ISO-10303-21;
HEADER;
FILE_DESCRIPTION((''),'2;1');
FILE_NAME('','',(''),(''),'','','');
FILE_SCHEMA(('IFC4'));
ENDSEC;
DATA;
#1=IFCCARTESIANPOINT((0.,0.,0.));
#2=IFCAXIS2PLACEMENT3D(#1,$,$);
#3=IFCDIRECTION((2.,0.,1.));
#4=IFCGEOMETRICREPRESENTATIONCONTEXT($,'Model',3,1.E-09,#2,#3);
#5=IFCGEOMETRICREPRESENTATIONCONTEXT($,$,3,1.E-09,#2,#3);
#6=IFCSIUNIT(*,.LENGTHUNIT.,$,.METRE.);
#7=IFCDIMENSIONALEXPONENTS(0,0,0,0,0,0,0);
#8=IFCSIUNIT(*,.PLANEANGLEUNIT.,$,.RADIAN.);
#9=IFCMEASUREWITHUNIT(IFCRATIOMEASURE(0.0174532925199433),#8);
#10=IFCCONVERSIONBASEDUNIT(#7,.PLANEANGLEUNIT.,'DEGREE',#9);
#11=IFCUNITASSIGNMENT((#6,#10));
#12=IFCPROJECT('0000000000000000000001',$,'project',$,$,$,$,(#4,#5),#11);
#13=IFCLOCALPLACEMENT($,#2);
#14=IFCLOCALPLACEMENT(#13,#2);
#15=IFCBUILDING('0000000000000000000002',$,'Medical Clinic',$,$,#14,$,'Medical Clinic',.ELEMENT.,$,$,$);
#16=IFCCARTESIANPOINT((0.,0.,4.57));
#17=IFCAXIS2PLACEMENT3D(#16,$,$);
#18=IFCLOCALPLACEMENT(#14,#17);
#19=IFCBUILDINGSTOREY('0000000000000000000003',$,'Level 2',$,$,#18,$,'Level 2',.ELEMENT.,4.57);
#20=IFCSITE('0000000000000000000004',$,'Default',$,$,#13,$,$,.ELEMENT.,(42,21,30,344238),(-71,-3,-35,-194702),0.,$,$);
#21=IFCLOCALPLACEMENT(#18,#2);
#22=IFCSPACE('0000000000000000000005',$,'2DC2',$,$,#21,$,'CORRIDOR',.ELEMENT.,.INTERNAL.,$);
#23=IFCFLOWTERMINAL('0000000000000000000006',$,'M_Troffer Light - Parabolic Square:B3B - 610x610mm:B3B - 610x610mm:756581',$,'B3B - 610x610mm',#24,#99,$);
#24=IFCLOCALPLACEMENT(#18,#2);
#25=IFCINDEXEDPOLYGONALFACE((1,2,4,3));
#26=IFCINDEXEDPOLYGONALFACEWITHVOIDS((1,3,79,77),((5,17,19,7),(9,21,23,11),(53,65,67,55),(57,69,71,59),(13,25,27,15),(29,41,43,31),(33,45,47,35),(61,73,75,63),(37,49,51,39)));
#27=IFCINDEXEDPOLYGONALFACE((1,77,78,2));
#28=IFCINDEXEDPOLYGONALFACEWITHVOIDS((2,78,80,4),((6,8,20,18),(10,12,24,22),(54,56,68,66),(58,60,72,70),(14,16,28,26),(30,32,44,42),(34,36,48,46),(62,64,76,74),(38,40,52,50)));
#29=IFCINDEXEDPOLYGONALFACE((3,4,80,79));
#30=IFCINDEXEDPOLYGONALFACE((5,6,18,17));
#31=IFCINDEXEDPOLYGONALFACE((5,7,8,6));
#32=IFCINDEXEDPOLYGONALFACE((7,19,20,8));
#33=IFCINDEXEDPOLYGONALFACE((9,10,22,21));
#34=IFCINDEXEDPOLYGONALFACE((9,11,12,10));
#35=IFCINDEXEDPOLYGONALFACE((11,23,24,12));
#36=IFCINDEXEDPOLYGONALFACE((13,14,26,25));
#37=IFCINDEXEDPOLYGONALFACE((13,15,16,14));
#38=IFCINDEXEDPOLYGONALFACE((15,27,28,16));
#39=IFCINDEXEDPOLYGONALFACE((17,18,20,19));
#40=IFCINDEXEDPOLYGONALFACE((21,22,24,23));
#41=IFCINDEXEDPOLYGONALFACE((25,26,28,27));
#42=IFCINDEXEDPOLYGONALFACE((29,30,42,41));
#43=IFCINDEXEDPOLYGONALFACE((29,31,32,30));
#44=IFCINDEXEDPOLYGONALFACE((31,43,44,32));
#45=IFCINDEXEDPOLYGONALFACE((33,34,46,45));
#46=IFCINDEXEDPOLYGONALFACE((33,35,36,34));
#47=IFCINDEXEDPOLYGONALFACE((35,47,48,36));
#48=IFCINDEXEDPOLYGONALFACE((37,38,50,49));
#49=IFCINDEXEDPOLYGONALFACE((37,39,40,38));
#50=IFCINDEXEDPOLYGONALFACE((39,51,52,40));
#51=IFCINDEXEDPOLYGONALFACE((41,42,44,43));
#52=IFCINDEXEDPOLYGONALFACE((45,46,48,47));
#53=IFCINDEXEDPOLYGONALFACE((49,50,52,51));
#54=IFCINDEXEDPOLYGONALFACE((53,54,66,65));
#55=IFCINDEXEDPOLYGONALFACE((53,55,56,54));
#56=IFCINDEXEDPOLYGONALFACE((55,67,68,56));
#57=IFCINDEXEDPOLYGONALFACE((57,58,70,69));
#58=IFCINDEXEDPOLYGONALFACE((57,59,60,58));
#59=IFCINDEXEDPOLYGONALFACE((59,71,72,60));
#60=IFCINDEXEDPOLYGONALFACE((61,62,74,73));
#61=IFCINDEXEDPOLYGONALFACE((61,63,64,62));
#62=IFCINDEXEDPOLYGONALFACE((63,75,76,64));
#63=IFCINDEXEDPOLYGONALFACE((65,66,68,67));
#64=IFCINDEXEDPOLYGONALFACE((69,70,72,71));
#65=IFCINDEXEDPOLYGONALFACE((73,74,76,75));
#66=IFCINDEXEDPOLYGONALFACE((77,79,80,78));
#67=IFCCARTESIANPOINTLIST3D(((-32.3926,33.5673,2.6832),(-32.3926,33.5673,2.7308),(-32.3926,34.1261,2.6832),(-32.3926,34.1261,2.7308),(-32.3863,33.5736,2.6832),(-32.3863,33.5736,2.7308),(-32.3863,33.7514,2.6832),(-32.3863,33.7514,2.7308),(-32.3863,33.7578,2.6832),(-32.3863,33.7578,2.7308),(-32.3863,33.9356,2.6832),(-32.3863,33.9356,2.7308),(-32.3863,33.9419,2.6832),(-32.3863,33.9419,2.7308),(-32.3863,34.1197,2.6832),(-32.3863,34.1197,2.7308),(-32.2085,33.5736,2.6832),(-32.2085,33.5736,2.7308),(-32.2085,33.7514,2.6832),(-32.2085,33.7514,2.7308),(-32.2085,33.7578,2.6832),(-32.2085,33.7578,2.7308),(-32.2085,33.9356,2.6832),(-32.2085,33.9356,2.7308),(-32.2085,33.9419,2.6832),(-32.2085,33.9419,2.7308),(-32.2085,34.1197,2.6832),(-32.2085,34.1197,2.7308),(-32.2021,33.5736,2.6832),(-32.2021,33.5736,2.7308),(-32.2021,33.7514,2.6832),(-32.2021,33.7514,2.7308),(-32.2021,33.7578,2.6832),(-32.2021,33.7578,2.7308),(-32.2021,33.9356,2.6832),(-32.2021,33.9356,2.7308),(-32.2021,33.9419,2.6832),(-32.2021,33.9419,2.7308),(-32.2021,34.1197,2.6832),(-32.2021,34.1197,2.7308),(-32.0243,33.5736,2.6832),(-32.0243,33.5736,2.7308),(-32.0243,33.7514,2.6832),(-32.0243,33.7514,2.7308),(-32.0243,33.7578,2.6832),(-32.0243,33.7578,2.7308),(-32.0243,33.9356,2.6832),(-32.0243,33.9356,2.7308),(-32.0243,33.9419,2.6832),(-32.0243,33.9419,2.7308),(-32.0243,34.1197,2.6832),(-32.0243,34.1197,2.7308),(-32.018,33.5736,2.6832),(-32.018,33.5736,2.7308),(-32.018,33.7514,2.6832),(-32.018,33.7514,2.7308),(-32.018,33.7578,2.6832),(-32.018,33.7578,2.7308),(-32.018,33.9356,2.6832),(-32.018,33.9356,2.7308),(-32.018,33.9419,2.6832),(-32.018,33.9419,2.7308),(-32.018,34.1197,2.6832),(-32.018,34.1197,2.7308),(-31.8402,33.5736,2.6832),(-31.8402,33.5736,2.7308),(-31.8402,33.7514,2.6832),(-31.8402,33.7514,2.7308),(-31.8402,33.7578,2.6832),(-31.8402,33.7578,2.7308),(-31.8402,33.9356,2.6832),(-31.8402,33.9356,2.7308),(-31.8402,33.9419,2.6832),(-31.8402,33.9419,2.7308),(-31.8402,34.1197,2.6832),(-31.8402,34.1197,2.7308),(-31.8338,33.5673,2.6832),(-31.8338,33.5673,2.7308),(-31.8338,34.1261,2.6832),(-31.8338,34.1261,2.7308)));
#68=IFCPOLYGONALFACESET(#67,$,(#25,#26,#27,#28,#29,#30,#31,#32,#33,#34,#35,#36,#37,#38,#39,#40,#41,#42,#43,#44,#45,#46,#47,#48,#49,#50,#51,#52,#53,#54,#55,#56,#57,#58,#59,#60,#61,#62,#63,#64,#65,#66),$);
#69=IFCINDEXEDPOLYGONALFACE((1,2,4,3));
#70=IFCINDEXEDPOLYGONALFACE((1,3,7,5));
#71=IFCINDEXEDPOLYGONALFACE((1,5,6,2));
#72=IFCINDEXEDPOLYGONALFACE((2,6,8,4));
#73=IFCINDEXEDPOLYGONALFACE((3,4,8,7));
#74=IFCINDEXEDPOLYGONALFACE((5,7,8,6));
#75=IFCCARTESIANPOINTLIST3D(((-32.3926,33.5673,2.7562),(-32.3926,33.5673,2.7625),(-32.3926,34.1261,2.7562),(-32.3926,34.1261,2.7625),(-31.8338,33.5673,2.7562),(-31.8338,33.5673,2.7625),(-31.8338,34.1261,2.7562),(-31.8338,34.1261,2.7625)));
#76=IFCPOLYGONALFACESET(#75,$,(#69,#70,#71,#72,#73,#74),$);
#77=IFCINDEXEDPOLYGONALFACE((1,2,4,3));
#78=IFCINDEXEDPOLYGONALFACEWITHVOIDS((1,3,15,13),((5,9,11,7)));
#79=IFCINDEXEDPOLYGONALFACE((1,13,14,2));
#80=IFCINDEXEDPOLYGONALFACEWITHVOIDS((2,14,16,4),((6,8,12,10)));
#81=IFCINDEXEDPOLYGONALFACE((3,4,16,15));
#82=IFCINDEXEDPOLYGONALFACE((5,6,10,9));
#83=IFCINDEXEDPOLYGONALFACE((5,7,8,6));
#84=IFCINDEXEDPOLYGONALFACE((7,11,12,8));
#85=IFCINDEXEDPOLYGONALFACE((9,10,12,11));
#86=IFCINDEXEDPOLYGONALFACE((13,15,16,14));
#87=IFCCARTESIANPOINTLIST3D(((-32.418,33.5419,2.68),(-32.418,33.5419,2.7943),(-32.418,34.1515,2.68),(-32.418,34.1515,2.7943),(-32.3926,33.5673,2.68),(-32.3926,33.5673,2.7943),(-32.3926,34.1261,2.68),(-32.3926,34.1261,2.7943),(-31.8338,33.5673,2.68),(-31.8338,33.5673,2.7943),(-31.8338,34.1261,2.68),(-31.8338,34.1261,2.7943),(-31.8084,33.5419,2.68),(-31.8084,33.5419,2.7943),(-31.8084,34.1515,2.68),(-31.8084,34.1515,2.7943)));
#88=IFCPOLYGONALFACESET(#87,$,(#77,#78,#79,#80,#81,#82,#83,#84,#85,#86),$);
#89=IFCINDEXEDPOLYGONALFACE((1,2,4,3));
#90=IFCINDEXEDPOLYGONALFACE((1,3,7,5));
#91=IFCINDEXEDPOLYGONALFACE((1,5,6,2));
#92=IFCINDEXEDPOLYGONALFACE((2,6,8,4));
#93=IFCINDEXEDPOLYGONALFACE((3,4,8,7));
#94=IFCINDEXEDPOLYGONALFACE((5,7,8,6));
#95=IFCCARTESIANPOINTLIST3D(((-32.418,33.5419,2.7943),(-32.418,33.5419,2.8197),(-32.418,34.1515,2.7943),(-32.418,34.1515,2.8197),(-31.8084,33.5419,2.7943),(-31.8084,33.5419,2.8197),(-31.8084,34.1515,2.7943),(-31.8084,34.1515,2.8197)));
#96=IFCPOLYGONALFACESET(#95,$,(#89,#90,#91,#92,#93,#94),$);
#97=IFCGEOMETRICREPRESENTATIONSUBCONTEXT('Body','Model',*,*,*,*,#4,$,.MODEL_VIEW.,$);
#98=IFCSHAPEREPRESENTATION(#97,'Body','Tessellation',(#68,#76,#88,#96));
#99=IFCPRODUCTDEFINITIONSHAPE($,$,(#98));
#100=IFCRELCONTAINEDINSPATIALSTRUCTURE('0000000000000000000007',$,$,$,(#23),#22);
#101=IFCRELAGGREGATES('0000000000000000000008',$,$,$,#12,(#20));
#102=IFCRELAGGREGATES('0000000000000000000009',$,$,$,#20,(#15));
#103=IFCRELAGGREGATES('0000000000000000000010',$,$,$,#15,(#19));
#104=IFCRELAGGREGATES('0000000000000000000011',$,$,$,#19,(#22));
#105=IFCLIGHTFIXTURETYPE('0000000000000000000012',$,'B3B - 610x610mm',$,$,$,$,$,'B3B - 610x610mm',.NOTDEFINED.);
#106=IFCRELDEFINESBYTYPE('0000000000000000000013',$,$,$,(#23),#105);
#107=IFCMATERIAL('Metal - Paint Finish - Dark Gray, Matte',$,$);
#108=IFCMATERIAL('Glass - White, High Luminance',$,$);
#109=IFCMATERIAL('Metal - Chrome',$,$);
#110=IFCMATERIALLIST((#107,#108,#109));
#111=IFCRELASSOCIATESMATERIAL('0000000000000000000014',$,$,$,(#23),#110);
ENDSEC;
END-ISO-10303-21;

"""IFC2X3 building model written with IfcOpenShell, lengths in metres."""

from ifc_helpers import new_model, entity, si_unit, converted_unit, direction, frame, origin, origin_2d_with_axis, place, context, subcontext, project, spatial, polyline, rectangle, outline, extrude, source, transform, mapped, material, material_list, type_object, type_shapes, element, save


model = new_model("IFC2X3")

# Units and contexts
model_context = context("Model", 3, precision=1e-09, world=origin(), true_north=direction((2.0, 0.0, 1.0)))
context_of_model = context(None, 3, precision=1e-09, world=origin(), true_north=direction((2.0, 0.0, 1.0)))
body_context = subcontext(model_context, "Body", "Model", "MODEL_VIEW")
ifc_project = project(units=[si_unit("LENGTHUNIT", "METRE"), converted_unit("PLANEANGLEUNIT", "DEGREE", entity("IfcRatioMeasure", 0.0174532925199433), si_unit("PLANEANGLEUNIT", "RADIAN"), dimensions=[0, 0, 0, 0, 0, 0, 0])], contexts=[model_context, context_of_model])

# Site, building, storey, space
site_placement = place(None, origin())
site = spatial("IfcSite", under=ifc_project, at=site_placement, Name="Default", CompositionType="ELEMENT", RefLatitude=(42, 21, 30, 344238), RefLongitude=(-71, -3, -35, -194702), RefElevation=0.0)
building_placement = place(site_placement, origin())
building = spatial("IfcBuilding", under=site, at=building_placement, Name="Medical Clinic", LongName="Medical Clinic", CompositionType="ELEMENT")
storey_placement = place(building_placement, frame((0.0, 0.0, 4.57)))
storey = spatial("IfcBuildingStorey", under=building, at=storey_placement, Name="Level 2", LongName="Level 2", CompositionType="ELEMENT", Elevation=4.57)
space_1_placement = place(storey_placement, origin())
space_1 = spatial("IfcSpace", under=storey, at=space_1_placement, Name="2DC2", LongName="CORRIDOR", CompositionType="ELEMENT", InteriorOrExteriorSpace="INTERNAL")

# Flow terminal
ifc_material_1 = material(Name="Metal - Paint Finish - Dark Gray, Matte")
ifc_material_2 = material(Name="Glass - White, High Luminance")
ifc_material_3 = material(Name="Metal - Chrome")
ifc_material_list_1 = material_list([ifc_material_1, ifc_material_2, ifc_material_3])
light_fixture_type_1 = type_object("IfcLightFixtureType", Name="B3B - 610x610mm", ElementType="B3B - 610x610mm", PredefinedType="NOTDEFINED")
shared_shape_1 = source(origin(), body_context, "Body", "SweptSolid", [
    extrude(outline(polyline([(-0.2794, -0.2794), (0.2794, -0.2794), (0.2794, 0.2794), (-0.2794, 0.2794), (-0.2794, -0.2794)]), holes=[polyline([(-0.0952, 0.0953), (-0.273, 0.0953), (-0.273, 0.2731), (-0.0952, 0.2731), (-0.0952, 0.0953)]), polyline([(0.2731, 0.0953), (0.0953, 0.0953), (0.0953, 0.2731), (0.2731, 0.2731), (0.2731, 0.0953)]), polyline([(-0.0889, 0.2731), (0.0889, 0.2731), (0.0889, 0.0953), (-0.0889, 0.0953), (-0.0889, 0.2731)]), polyline([(0.2731, -0.273), (0.0953, -0.273), (0.0953, -0.0952), (0.2731, -0.0952), (0.2731, -0.273)]), polyline([(0.0889, -0.273), (-0.0889, -0.273), (-0.0889, -0.0952), (0.0889, -0.0952), (0.0889, -0.273)]), polyline([(-0.0952, -0.273), (-0.273, -0.273), (-0.273, -0.0952), (-0.0952, -0.0952), (-0.0952, -0.273)]), polyline([(-0.0952, -0.0889), (-0.273, -0.0889), (-0.273, 0.0889), (-0.0952, 0.0889), (-0.0952, -0.0889)]), polyline([(0.0889, -0.0889), (-0.0889, -0.0889), (-0.0889, 0.0889), (0.0889, 0.0889), (0.0889, -0.0889)]), polyline([(0.2731, -0.0889), (0.0953, -0.0889), (0.0953, 0.0889), (0.2731, 0.0889), (0.2731, -0.0889)])]), frame((0.0, -0.3048, -0.0508), z_axis=(0.0, 0.0, 1.0), x_axis=(-1.0, 0.0, 0.0)), (0.0, 0.0, 1.0), 0.0476),
    extrude(rectangle(XDim=0.5588, YDim=0.5588, at=origin_2d_with_axis()), frame((0.0, -0.3048, -0.0825), z_axis=(0.0, 0.0, 1.0), x_axis=(-1.0, 0.0, 0.0)), (0.0, 0.0, 1.0), 0.0064),
    extrude(outline(polyline([(-0.3048, -0.3048), (0.3048, -0.3048), (0.3048, 0.3048), (-0.3048, 0.3048), (-0.3048, -0.3048)]), holes=[polyline([(0.2794, 0.2794), (0.2794, -0.2794), (-0.2794, -0.2794), (-0.2794, 0.2794), (0.2794, 0.2794)])]), frame((0.0, -0.3048, -0.1143)), (0.0, 0.0, 1.0), 0.1143),
    extrude(rectangle(XDim=0.6096, YDim=0.6096, at=origin_2d_with_axis()), frame((0.0, -0.3048, -0.1397), z_axis=(0.0, 0.0, 1.0), x_axis=(-1.0, 0.0, 0.0)), (0.0, 0.0, 1.0), 0.0254),
])
type_shapes(light_fixture_type_1, [shared_shape_1])
flow_terminal_1_placement = place(space_1_placement, frame((-32.1132, 33.5419, 2.68), z_axis=(0.0, 0.0, -1.0), x_axis=(1.0, 0.0, 0.0)))
element("IfcFlowTerminal", 1, at=flow_terminal_1_placement, inside=space_1, type_object=light_fixture_type_1, material=ifc_material_list_1, Name="M_Troffer Light - Parabolic Square:B3B - 610x610mm:B3B - 610x610mm:756581", ObjectType="B3B - 610x610mm", context=body_context, shape_type="MappedRepresentation", body=[
    mapped(shared_shape_1, transform((0.0, 0.0, 0.0), scale=1.0)),
])

save(model, "model.ifc")
